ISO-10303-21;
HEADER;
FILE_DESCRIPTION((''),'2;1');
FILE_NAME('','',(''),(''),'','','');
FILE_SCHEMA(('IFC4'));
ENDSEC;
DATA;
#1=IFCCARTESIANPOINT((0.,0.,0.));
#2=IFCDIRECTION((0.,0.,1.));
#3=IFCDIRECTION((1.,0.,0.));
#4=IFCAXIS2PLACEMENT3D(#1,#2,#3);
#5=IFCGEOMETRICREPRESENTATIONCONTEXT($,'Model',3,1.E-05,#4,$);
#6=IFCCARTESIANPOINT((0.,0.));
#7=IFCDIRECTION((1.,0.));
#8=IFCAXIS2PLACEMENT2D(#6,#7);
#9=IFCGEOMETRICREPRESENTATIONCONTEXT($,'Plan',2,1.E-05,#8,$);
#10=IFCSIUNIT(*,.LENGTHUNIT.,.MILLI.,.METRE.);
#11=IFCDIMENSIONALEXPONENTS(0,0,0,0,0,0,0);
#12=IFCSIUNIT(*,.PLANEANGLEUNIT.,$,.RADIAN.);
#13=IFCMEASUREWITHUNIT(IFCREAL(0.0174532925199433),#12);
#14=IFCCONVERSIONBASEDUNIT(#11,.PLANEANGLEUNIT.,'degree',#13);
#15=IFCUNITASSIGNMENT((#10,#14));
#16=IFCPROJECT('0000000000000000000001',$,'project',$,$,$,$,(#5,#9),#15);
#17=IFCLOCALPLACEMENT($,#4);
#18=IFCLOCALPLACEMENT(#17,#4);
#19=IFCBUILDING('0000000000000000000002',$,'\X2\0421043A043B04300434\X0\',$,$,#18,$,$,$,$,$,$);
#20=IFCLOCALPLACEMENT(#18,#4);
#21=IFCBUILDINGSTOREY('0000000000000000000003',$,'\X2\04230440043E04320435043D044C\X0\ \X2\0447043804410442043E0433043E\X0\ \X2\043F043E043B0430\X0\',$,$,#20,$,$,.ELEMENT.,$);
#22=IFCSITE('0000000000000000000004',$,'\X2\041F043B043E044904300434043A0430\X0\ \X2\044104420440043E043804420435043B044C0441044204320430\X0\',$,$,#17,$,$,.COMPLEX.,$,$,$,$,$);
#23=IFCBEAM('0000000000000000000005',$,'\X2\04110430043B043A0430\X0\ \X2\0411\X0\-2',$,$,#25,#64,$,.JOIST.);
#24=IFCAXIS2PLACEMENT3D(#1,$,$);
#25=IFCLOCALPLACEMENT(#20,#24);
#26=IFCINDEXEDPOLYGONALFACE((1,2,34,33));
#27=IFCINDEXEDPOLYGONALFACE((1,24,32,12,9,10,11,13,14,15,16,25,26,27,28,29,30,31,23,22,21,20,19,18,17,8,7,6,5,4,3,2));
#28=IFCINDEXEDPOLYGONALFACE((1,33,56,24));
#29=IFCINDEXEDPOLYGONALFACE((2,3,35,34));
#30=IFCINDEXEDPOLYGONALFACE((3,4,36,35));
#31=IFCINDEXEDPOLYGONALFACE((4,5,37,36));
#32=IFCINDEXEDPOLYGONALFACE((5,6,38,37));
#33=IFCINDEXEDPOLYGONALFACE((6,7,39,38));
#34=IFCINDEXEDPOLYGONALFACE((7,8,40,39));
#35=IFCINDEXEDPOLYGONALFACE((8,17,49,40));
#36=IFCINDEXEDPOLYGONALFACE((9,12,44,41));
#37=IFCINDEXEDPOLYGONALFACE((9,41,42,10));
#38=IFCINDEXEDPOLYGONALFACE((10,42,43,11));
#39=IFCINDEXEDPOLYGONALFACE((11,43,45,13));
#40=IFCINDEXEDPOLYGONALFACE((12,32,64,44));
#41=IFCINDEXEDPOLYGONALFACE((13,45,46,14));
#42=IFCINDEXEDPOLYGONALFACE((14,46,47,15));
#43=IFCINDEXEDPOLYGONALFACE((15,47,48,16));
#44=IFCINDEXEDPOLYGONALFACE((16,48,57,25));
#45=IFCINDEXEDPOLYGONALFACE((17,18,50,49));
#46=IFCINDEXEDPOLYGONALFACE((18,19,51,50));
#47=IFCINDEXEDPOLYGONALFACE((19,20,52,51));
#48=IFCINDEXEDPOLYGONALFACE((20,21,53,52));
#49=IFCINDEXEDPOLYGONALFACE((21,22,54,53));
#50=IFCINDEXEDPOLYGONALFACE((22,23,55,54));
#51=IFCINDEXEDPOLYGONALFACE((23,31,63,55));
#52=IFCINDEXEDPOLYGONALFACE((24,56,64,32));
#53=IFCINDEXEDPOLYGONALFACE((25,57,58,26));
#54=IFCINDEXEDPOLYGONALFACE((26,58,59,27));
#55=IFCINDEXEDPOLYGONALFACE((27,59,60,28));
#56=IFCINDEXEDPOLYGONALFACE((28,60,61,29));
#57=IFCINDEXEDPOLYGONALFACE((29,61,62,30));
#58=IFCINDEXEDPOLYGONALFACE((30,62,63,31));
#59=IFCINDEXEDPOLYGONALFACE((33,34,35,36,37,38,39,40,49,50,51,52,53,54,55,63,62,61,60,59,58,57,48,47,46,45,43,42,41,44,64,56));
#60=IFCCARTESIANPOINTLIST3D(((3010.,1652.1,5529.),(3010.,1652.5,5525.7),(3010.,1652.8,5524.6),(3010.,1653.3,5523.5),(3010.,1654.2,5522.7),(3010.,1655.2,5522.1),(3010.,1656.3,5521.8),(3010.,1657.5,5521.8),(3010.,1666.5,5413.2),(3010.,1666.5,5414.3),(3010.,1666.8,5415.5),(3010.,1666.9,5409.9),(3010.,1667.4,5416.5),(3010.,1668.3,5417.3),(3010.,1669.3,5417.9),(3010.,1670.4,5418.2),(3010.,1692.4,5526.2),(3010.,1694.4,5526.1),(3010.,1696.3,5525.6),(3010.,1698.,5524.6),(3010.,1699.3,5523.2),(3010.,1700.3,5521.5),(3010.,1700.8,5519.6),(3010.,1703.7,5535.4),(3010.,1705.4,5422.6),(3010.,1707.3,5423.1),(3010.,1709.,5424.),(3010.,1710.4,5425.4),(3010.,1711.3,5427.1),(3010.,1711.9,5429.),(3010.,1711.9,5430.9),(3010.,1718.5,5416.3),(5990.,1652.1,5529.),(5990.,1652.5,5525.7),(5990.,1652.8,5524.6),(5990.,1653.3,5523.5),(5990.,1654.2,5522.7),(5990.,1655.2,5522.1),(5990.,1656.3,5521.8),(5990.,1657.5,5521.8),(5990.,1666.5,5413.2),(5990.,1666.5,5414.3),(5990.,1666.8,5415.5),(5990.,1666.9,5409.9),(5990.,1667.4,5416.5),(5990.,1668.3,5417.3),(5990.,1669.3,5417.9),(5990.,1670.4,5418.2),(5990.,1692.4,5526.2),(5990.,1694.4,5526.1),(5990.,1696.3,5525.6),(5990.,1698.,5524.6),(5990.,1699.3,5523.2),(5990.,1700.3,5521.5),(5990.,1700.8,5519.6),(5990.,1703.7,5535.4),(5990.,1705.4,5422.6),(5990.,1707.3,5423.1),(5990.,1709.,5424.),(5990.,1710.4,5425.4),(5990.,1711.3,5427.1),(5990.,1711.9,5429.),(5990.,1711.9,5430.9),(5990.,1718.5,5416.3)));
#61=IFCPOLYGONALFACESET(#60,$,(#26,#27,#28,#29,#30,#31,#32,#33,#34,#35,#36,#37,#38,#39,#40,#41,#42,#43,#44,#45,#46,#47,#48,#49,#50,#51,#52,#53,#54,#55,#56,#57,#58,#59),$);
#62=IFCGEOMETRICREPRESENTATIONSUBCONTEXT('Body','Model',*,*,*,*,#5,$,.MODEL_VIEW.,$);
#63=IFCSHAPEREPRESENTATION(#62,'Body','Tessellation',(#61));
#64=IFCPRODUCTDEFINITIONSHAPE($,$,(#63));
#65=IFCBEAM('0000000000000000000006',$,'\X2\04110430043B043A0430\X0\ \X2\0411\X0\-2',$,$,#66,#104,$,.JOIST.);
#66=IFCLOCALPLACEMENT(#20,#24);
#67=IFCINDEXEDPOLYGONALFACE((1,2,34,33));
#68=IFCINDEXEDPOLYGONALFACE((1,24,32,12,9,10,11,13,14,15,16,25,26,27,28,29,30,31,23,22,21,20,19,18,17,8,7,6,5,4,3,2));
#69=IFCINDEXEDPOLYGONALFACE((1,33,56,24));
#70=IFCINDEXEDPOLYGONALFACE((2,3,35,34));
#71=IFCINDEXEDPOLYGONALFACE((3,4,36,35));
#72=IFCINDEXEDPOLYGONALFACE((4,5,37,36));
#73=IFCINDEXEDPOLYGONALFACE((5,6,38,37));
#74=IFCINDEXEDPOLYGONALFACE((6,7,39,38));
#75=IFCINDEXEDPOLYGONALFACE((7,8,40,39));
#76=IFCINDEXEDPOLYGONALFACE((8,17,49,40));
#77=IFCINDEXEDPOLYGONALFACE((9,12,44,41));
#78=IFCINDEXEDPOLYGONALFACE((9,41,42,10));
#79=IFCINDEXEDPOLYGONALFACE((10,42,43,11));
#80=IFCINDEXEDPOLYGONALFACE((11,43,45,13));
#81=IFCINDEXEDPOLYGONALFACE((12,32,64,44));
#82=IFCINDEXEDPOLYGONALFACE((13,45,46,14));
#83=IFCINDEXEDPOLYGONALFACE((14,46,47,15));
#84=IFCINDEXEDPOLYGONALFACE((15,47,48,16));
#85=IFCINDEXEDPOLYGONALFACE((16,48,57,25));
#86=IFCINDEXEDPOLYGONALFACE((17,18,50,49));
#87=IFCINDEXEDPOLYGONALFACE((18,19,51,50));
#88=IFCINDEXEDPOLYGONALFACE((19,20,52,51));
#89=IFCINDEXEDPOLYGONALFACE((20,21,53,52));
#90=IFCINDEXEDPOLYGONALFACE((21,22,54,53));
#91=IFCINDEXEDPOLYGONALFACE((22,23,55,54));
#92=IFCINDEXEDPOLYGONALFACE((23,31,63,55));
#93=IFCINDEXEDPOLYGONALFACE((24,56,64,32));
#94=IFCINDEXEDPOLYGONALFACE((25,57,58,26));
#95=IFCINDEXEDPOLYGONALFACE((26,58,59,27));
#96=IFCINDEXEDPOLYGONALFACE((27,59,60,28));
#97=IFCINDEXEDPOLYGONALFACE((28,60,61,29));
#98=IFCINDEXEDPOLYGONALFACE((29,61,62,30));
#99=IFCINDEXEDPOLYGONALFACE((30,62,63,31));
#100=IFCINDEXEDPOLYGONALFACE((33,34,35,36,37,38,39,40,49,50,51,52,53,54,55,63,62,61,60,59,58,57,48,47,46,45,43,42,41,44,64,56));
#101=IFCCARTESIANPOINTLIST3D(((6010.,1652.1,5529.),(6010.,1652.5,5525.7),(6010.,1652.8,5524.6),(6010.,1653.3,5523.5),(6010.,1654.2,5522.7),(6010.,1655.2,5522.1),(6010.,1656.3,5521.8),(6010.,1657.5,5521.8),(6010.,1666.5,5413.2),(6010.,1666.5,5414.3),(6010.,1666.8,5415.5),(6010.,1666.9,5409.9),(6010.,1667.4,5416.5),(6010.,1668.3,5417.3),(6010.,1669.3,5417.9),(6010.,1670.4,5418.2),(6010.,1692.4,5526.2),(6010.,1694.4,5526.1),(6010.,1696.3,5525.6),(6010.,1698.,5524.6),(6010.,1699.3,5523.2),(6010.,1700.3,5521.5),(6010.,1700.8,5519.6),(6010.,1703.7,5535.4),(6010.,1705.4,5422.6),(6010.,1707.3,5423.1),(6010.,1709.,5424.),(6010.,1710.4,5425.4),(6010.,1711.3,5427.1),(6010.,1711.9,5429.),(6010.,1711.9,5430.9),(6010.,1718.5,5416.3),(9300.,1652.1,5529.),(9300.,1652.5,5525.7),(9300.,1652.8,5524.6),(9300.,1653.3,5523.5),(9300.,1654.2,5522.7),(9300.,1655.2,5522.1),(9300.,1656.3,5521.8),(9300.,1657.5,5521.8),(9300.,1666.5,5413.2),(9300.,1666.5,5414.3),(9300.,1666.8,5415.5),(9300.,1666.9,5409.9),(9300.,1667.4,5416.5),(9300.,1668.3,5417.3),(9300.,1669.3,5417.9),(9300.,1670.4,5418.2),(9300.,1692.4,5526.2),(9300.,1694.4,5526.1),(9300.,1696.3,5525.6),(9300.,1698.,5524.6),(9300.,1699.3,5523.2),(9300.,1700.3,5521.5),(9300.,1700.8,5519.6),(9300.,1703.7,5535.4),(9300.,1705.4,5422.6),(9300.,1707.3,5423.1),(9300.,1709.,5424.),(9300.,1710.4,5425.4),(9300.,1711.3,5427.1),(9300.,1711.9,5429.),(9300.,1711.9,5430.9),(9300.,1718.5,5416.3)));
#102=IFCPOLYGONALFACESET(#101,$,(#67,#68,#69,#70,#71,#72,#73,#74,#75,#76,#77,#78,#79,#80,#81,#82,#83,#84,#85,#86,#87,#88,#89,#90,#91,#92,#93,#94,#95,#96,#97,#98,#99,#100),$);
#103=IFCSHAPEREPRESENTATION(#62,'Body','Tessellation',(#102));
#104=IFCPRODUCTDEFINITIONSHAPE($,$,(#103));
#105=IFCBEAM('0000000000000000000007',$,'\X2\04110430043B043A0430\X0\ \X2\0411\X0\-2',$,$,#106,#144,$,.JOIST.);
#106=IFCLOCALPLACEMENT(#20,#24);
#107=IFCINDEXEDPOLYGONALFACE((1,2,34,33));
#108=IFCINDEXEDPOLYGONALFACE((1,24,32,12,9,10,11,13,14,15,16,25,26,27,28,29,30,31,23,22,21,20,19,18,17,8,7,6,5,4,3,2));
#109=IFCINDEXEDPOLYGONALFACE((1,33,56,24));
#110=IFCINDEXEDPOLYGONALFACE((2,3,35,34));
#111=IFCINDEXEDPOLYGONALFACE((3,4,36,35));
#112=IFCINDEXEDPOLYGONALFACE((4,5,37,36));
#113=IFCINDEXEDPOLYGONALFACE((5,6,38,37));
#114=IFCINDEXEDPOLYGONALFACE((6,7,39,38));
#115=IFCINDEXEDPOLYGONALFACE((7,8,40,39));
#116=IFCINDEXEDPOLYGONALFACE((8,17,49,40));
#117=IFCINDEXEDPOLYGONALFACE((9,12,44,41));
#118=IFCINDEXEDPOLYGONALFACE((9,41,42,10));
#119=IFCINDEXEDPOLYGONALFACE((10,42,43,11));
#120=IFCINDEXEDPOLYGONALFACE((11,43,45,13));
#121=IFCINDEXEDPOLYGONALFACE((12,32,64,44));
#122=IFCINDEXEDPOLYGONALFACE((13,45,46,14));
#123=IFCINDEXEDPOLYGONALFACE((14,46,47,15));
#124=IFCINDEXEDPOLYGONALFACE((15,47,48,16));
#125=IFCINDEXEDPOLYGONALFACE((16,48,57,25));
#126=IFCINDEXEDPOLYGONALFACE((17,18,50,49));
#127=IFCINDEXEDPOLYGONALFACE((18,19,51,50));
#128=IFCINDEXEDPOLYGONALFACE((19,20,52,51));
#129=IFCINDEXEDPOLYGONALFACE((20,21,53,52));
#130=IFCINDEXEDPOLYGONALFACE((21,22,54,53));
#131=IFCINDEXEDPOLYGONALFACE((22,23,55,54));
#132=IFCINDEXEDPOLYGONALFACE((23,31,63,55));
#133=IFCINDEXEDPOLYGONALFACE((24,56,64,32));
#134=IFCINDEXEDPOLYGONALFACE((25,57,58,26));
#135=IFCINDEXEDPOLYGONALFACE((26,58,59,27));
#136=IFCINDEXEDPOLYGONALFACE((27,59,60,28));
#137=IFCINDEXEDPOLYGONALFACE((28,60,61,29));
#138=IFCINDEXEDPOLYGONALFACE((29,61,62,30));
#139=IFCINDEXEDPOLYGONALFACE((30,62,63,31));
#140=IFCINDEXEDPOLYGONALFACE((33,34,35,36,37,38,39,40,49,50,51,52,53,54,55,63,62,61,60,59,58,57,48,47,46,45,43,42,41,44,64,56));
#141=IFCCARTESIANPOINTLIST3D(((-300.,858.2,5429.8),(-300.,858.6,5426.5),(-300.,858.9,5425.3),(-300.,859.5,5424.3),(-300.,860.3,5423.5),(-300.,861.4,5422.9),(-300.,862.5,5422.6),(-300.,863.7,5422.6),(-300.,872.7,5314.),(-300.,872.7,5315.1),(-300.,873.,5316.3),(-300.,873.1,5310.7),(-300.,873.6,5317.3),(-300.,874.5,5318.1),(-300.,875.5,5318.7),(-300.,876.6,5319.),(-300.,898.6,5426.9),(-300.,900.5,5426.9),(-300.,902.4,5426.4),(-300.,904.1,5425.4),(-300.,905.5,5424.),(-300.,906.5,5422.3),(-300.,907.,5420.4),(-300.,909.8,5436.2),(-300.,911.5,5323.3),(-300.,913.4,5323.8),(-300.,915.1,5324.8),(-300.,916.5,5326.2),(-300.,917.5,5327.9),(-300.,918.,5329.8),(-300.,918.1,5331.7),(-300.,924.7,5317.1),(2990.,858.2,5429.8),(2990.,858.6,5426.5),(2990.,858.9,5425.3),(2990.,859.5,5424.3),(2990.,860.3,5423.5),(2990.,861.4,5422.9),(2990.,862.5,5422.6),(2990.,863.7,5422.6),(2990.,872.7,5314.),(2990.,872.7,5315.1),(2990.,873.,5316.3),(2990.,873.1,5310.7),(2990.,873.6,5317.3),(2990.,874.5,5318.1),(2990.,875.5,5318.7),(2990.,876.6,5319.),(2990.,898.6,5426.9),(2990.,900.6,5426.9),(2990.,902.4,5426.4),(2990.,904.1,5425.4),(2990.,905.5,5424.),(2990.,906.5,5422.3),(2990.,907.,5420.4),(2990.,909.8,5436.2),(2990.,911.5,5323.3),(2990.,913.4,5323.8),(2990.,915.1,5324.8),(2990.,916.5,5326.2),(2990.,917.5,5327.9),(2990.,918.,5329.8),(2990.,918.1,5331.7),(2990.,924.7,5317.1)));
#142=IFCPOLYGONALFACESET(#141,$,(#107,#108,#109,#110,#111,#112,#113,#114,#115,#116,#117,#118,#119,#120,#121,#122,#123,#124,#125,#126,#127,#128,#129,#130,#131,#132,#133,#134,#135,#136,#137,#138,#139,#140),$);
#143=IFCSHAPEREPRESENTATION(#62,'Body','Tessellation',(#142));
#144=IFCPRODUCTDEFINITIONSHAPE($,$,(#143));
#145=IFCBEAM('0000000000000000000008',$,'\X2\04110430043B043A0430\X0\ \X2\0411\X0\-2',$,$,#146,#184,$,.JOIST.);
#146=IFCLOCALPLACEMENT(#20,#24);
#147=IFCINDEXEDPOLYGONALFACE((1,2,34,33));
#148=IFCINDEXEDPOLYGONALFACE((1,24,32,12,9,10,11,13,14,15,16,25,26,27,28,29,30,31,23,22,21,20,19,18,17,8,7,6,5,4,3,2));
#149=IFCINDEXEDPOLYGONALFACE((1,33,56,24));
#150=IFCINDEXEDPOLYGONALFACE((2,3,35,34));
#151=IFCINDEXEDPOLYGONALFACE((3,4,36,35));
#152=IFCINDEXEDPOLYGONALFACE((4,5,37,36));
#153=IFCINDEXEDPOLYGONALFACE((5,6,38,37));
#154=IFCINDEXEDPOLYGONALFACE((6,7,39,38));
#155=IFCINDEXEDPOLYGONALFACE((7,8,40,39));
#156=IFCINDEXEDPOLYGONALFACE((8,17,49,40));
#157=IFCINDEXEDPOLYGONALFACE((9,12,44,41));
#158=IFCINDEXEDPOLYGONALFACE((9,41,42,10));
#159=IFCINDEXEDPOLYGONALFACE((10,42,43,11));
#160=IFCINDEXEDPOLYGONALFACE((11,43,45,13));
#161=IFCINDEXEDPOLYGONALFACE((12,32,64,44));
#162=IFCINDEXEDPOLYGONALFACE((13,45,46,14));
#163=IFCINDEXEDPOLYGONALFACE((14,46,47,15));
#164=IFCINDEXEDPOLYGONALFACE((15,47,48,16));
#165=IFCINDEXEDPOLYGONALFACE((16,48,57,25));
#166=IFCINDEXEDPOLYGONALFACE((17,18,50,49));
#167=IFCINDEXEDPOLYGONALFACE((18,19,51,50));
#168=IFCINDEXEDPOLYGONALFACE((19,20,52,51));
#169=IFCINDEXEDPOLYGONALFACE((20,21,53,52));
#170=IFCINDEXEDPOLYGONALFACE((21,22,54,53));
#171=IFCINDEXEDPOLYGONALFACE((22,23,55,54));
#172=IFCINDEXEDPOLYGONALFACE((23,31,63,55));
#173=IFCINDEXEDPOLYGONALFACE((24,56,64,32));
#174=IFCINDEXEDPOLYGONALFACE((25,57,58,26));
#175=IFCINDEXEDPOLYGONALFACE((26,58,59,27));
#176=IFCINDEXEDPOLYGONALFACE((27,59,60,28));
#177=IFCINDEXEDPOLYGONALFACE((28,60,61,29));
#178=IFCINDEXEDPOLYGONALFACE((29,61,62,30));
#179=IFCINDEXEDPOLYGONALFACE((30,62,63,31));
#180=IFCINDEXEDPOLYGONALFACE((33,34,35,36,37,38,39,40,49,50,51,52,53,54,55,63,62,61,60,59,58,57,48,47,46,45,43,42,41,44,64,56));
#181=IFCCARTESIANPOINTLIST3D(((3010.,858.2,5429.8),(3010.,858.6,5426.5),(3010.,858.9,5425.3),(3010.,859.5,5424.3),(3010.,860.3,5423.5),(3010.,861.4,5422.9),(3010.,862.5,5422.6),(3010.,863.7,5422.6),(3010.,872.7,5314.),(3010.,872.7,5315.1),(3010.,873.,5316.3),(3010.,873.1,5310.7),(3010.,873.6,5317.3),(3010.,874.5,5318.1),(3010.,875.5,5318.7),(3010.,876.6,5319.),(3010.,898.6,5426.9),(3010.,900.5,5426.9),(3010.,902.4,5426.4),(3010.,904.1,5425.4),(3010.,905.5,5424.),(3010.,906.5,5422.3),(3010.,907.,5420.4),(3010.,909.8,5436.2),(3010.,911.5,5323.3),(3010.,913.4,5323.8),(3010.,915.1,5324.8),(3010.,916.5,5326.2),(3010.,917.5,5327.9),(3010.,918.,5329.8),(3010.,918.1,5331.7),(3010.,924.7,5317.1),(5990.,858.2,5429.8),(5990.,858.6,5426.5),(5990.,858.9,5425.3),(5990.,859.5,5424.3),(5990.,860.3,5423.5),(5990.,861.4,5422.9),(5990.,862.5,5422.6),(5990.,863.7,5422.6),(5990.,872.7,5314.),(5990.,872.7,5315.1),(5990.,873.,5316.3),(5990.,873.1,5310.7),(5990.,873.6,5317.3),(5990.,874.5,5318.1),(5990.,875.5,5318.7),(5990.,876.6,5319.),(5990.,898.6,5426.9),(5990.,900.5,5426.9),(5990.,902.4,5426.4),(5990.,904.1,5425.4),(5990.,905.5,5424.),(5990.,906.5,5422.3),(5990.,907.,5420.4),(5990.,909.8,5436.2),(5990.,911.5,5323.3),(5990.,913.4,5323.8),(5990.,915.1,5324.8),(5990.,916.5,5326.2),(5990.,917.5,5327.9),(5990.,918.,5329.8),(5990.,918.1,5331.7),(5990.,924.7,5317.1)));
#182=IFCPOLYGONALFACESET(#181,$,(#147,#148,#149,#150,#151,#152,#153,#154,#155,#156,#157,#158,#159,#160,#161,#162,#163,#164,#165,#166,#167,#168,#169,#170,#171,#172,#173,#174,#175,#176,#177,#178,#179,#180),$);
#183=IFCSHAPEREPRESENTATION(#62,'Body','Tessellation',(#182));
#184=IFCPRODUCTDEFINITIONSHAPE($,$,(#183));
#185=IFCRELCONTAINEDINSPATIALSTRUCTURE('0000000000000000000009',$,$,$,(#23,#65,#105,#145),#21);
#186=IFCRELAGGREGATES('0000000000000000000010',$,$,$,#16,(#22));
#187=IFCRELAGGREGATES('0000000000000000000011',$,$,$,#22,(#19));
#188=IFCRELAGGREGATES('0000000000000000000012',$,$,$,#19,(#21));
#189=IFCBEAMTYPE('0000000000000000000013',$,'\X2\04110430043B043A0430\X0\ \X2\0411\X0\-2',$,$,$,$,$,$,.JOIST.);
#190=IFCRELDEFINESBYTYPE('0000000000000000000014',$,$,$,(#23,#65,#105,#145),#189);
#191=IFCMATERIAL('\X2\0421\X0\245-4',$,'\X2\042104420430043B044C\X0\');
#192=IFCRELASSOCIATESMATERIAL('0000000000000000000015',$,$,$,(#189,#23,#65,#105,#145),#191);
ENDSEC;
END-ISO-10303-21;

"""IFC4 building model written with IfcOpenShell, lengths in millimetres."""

from ifc_helpers import new_model, entity, si_unit, converted_unit, frame, origin_with_axes, origin_2d_with_axis, place, context, subcontext, project, spatial, u_section, extrude, material, material_profile, profile_set, profile_usage, type_object, element, save


model = new_model("IFC4")

# Units and contexts
model_context = context("Model", 3, precision=1e-05, world=origin_with_axes())
plan_context = context("Plan", 2, precision=1e-05, world=origin_2d_with_axis())
body_context = subcontext(model_context, "Body", "Model", "MODEL_VIEW")
ifc_project = project(units=[si_unit("LENGTHUNIT", "METRE", prefix="MILLI"), converted_unit("PLANEANGLEUNIT", "degree", entity("IfcReal", 0.0174532925199433), si_unit("PLANEANGLEUNIT", "RADIAN"), dimensions=[0, 0, 0, 0, 0, 0, 0])], contexts=[model_context, plan_context])

# Site, building, storey
site_placement = place(None, origin_with_axes())
site = spatial("IfcSite", under=ifc_project, at=site_placement, Name="Площадка строительства", CompositionType="COMPLEX")
building_placement = place(site_placement, origin_with_axes())
building = spatial("IfcBuilding", under=site, at=building_placement, Name="Склад")
storey_placement = place(building_placement, origin_with_axes())
storey = spatial("IfcBuildingStorey", under=building, at=storey_placement, Name="Уровень чистого пола", CompositionType="ELEMENT")

# Beams
ifc_material_1 = material(Name="С245-4", Category="Сталь")
ifc_material_profile_1 = material_profile(ifc_material_1, u_section(Depth=120.0, FlangeWidth=52.0, WebThickness=4.8, FlangeThickness=7.8, FilletRadius=7.5, EdgeRadius=4.5, FlangeSlope=0.0))
ifc_profile_set_1 = profile_set([ifc_material_profile_1], Name="U12P_S245-4")
beam_type_1 = type_object("IfcBeamType", Name="Балка Б-2", PredefinedType="JOIST", material=ifc_profile_set_1)
ifc_profile_usage_1 = profile_usage(ifc_profile_set_1, cardinal=3)
beam_1_placement = place(storey_placement, frame((5990.0, 1718.5, 5416.3), z_axis=(-1.0, 0.0, 0.0), x_axis=(0.0, -0.99228, -0.12402)))
element("IfcBeam", 1, at=beam_1_placement, inside=storey, type_object=beam_type_1, material=ifc_profile_usage_1, Name="Балка Б-2", PredefinedType="JOIST", context=body_context, shape_type="SweptSolid", body=[
    extrude(u_section(Depth=120.0, FlangeWidth=52.0, WebThickness=4.8, FlangeThickness=7.8, FilletRadius=7.5, EdgeRadius=4.5, FlangeSlope=0.0), frame((26.0, 60.0, 0.0), z_axis=(0.0, 0.0, 1.0), x_axis=(1.0, 0.0, 0.0)), (0.0, 0.0, 1.0), 2980.0),
])
ifc_profile_usage_2 = profile_usage(ifc_profile_set_1, cardinal=3)
beam_2_placement = place(storey_placement, frame((9300.0, 1718.5, 5416.3), z_axis=(-1.0, 0.0, 0.0), x_axis=(0.0, -0.99228, -0.12402)))
element("IfcBeam", 2, at=beam_2_placement, inside=storey, type_object=beam_type_1, material=ifc_profile_usage_2, Name="Балка Б-2", PredefinedType="JOIST", context=body_context, shape_type="SweptSolid", body=[
    extrude(u_section(Depth=120.0, FlangeWidth=52.0, WebThickness=4.8, FlangeThickness=7.8, FilletRadius=7.5, EdgeRadius=4.5, FlangeSlope=0.0), frame((26.0, 60.0, 0.0), z_axis=(0.0, 0.0, 1.0), x_axis=(1.0, 0.0, 0.0)), (0.0, 0.0, 1.0), 3290.0),
])
ifc_profile_usage_3 = profile_usage(ifc_profile_set_1, cardinal=3)
beam_3_placement = place(storey_placement, frame((2990.0, 924.7, 5317.1), z_axis=(-1.0, 0.0, 0.0), x_axis=(0.0, -0.99228, -0.124019)))
element("IfcBeam", 3, at=beam_3_placement, inside=storey, type_object=beam_type_1, material=ifc_profile_usage_3, Name="Балка Б-2", PredefinedType="JOIST", context=body_context, shape_type="SweptSolid", body=[
    extrude(u_section(Depth=120.0, FlangeWidth=52.0, WebThickness=4.8, FlangeThickness=7.8, FilletRadius=7.5, EdgeRadius=4.5, FlangeSlope=0.0), frame((26.0, 60.0, 0.0), z_axis=(0.0, 0.0, 1.0), x_axis=(1.0, 0.0, 0.0)), (0.0, 0.0, 1.0), 3290.0),
])
ifc_profile_usage_4 = profile_usage(ifc_profile_set_1, cardinal=3)
beam_4_placement = place(storey_placement, frame((5990.0, 924.7, 5317.1), z_axis=(-1.0, 0.0, 0.0), x_axis=(0.0, -0.99228, -0.12402)))
element("IfcBeam", 4, at=beam_4_placement, inside=storey, type_object=beam_type_1, material=ifc_profile_usage_4, Name="Балка Б-2", PredefinedType="JOIST", context=body_context, shape_type="SweptSolid", body=[
    extrude(u_section(Depth=120.0, FlangeWidth=52.0, WebThickness=4.8, FlangeThickness=7.8, FilletRadius=7.5, EdgeRadius=4.5, FlangeSlope=0.0), frame((26.0, 60.0, 0.0), z_axis=(0.0, 0.0, 1.0), x_axis=(1.0, 0.0, 0.0)), (0.0, 0.0, 1.0), 2980.0),
])

save(model, "model.ifc")
